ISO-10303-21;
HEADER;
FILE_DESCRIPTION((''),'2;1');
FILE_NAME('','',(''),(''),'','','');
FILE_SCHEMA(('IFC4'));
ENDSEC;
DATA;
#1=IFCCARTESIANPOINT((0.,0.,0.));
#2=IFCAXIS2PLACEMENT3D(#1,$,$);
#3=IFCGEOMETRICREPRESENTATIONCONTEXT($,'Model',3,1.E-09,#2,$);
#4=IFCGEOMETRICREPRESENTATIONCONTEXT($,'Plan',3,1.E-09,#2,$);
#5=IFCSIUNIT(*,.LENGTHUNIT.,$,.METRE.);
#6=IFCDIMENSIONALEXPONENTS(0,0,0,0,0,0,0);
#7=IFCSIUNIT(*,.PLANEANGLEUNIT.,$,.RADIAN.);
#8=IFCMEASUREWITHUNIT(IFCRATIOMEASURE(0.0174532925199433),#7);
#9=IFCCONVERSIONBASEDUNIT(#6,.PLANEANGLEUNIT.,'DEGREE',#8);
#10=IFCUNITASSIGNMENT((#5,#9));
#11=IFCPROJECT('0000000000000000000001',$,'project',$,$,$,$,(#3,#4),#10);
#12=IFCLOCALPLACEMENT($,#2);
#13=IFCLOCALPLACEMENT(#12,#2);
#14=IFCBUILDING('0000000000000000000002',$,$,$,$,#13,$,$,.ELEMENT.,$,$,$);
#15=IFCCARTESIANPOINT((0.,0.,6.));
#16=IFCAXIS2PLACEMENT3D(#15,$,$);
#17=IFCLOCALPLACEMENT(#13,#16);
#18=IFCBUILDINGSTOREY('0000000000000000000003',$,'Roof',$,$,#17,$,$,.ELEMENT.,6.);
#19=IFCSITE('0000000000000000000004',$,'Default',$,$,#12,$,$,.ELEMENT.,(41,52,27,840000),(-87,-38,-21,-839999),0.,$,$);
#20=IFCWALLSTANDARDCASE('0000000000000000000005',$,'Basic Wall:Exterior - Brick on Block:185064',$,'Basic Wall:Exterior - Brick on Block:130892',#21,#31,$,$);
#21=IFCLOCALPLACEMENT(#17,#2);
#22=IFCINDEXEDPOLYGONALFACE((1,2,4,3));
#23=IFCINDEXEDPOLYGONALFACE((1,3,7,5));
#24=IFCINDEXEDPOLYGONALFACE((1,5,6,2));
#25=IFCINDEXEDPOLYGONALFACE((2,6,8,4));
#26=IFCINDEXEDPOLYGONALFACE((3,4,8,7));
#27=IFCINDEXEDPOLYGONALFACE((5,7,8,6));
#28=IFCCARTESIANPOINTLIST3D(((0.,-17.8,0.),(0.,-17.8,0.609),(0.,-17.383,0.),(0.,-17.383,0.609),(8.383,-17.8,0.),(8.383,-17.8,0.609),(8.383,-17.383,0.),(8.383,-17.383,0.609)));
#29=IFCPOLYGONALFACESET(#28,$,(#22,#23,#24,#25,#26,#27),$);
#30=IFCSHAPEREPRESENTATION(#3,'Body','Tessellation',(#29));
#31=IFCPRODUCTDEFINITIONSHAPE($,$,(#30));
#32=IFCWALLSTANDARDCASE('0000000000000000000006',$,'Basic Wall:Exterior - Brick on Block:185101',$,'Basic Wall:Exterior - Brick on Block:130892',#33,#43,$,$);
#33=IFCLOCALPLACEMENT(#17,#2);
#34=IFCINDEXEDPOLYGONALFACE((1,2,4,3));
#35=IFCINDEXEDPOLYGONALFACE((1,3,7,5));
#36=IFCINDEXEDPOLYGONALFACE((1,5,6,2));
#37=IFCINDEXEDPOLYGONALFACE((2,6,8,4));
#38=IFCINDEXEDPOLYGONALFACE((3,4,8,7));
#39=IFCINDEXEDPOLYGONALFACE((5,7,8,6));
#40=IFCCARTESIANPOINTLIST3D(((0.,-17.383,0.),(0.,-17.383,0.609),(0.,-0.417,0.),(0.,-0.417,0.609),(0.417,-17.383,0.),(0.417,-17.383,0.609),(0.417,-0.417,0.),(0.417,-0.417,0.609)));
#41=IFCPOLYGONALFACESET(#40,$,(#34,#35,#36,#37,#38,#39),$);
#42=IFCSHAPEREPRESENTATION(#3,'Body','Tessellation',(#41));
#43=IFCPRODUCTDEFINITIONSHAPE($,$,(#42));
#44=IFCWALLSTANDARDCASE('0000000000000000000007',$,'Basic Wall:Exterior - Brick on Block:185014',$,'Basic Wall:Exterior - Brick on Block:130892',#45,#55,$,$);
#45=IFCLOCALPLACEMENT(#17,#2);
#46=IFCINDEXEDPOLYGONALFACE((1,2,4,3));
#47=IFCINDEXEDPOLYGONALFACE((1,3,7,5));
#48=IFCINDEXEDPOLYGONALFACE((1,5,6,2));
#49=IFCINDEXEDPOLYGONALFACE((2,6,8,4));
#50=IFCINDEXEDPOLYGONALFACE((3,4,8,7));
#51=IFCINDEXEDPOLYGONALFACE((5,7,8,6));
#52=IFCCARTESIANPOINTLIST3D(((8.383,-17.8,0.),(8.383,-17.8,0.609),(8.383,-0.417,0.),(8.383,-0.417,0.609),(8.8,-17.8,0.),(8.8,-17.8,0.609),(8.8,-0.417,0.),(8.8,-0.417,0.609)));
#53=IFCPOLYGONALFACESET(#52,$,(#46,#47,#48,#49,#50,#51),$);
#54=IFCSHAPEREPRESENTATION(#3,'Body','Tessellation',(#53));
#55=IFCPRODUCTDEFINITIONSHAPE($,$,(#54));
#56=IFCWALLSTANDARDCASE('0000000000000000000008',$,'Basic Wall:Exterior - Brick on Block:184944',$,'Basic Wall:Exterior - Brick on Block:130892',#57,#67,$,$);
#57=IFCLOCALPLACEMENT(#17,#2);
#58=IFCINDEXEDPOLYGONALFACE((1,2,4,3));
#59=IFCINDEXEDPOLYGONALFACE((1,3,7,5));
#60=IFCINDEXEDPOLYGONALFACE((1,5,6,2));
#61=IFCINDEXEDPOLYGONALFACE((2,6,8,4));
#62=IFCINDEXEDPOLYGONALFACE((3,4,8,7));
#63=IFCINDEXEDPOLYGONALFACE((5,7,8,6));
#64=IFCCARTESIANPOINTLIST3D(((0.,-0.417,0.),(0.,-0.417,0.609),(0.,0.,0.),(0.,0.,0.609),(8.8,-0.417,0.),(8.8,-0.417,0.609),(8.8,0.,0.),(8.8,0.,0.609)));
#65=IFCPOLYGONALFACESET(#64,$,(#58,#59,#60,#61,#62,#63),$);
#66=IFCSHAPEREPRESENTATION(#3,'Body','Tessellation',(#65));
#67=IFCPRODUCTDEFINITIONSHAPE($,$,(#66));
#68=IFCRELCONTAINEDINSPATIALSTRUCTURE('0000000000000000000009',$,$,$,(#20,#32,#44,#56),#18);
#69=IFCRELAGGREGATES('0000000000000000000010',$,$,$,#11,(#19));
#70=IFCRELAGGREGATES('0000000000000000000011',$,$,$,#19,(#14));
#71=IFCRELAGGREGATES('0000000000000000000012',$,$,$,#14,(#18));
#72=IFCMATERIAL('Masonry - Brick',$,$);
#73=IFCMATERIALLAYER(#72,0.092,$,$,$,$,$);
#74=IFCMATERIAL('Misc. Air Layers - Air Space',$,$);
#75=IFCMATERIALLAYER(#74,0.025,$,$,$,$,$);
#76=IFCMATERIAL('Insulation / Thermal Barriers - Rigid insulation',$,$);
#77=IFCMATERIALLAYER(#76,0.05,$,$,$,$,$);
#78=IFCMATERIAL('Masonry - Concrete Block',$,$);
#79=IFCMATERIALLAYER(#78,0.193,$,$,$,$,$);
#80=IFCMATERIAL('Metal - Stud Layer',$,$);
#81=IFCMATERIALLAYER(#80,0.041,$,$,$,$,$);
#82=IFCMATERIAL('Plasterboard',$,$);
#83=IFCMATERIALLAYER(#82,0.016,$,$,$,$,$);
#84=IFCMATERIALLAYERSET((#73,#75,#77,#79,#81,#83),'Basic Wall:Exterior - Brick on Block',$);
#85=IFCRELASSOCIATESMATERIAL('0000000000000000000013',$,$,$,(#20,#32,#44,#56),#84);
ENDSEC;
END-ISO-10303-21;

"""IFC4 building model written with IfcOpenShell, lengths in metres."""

from ifc_helpers import new_model, entity, si_unit, converted_unit, frame, frame_2d, origin, place, context, project, spatial, rectangle, extrude, material, layer, layer_set, layer_usage, element, save


model = new_model("IFC4")

# Units and contexts
model_context = context("Model", 3, precision=1e-09, world=origin())
plan_context = context("Plan", 3, precision=1e-09, world=origin())
ifc_project = project(units=[si_unit("LENGTHUNIT", "METRE"), converted_unit("PLANEANGLEUNIT", "DEGREE", entity("IfcRatioMeasure", 0.0174532925199433), si_unit("PLANEANGLEUNIT", "RADIAN"), dimensions=[0, 0, 0, 0, 0, 0, 0])], contexts=[model_context, plan_context])

# Site, building, storey
site_placement = place(None, origin())
site = spatial("IfcSite", under=ifc_project, at=site_placement, Name="Default", CompositionType="ELEMENT", RefLatitude=(41, 52, 27, 840000), RefLongitude=(-87, -38, -21, -839999), RefElevation=0.0)
building_placement = place(site_placement, origin())
building = spatial("IfcBuilding", under=site, at=building_placement, CompositionType="ELEMENT")
storey_placement = place(building_placement, frame((0.0, 0.0, 6.0)))
storey = spatial("IfcBuildingStorey", under=building, at=storey_placement, Name="Roof", CompositionType="ELEMENT", Elevation=6.0)

# Walls
ifc_material_1 = material(Name="Masonry - Brick")
ifc_layer_1 = layer(ifc_material_1, 0.092)
ifc_material_2 = material(Name="Misc. Air Layers - Air Space")
ifc_layer_2 = layer(ifc_material_2, 0.025)
ifc_material_3 = material(Name="Insulation / Thermal Barriers - Rigid insulation")
ifc_layer_3 = layer(ifc_material_3, 0.05)
ifc_material_4 = material(Name="Masonry - Concrete Block")
ifc_layer_4 = layer(ifc_material_4, 0.193)
ifc_material_5 = material(Name="Metal - Stud Layer")
ifc_layer_5 = layer(ifc_material_5, 0.041)
ifc_material_6 = material(Name="Plasterboard")
ifc_layer_6 = layer(ifc_material_6, 0.016)
ifc_layer_set = layer_set([ifc_layer_1, ifc_layer_2, ifc_layer_3, ifc_layer_4, ifc_layer_5, ifc_layer_6], Name="Basic Wall:Exterior - Brick on Block")
ifc_layer_usage_1 = layer_usage(ifc_layer_set, "AXIS2", "NEGATIVE", 0.2085)
wall_1_placement = place(storey_placement, frame((8.383, -17.5915, 0.0), z_axis=(0.0, 0.0, 1.0), x_axis=(-1.0, 0.0, 0.0)))
element("IfcWallStandardCase", 1, at=wall_1_placement, inside=storey, material=ifc_layer_usage_1, Name="Basic Wall:Exterior - Brick on Block:185064", ObjectType="Basic Wall:Exterior - Brick on Block:130892", context=model_context, shape_type="SweptSolid", body=[
    extrude(rectangle(XDim=8.383, YDim=0.417, at=frame_2d((4.1915, 0.0), x_axis=(-1.0, 0.0))), origin(), (0.0, 0.0, 1.0), 0.609),
])
ifc_layer_usage_2 = layer_usage(ifc_layer_set, "AXIS2", "NEGATIVE", 0.2085)
wall_2_placement = place(storey_placement, frame((0.2085, -17.383, 0.0), z_axis=(0.0, 0.0, 1.0), x_axis=(0.0, 1.0, 0.0)))
element("IfcWallStandardCase", 2, at=wall_2_placement, inside=storey, material=ifc_layer_usage_2, Name="Basic Wall:Exterior - Brick on Block:185101", ObjectType="Basic Wall:Exterior - Brick on Block:130892", context=model_context, shape_type="SweptSolid", body=[
    extrude(rectangle(XDim=16.966, YDim=0.417, at=frame_2d((8.483, 0.0), x_axis=(-1.0, 0.0))), origin(), (0.0, 0.0, 1.0), 0.609),
])
ifc_layer_usage_3 = layer_usage(ifc_layer_set, "AXIS2", "NEGATIVE", 0.2085)
wall_3_placement = place(storey_placement, frame((8.5915, -0.417, 0.0), z_axis=(0.0, 0.0, 1.0), x_axis=(0.0, -1.0, 0.0)))
element("IfcWallStandardCase", 3, at=wall_3_placement, inside=storey, material=ifc_layer_usage_3, Name="Basic Wall:Exterior - Brick on Block:185014", ObjectType="Basic Wall:Exterior - Brick on Block:130892", context=model_context, shape_type="SweptSolid", body=[
    extrude(rectangle(XDim=17.383, YDim=0.417, at=frame_2d((8.6915, 0.0), x_axis=(-1.0, 0.0))), origin(), (0.0, 0.0, 1.0), 0.609),
])
ifc_layer_usage_4 = layer_usage(ifc_layer_set, "AXIS2", "NEGATIVE", 0.2085)
wall_4_placement = place(storey_placement, frame((0.0, -0.2085, 0.0)))
element("IfcWallStandardCase", 4, at=wall_4_placement, inside=storey, material=ifc_layer_usage_4, Name="Basic Wall:Exterior - Brick on Block:184944", ObjectType="Basic Wall:Exterior - Brick on Block:130892", context=model_context, shape_type="SweptSolid", body=[
    extrude(rectangle(XDim=8.8, YDim=0.417, at=frame_2d((4.4, 0.0), x_axis=(-1.0, 0.0))), origin(), (0.0, 0.0, 1.0), 0.609),
])

save(model, "model.ifc")
